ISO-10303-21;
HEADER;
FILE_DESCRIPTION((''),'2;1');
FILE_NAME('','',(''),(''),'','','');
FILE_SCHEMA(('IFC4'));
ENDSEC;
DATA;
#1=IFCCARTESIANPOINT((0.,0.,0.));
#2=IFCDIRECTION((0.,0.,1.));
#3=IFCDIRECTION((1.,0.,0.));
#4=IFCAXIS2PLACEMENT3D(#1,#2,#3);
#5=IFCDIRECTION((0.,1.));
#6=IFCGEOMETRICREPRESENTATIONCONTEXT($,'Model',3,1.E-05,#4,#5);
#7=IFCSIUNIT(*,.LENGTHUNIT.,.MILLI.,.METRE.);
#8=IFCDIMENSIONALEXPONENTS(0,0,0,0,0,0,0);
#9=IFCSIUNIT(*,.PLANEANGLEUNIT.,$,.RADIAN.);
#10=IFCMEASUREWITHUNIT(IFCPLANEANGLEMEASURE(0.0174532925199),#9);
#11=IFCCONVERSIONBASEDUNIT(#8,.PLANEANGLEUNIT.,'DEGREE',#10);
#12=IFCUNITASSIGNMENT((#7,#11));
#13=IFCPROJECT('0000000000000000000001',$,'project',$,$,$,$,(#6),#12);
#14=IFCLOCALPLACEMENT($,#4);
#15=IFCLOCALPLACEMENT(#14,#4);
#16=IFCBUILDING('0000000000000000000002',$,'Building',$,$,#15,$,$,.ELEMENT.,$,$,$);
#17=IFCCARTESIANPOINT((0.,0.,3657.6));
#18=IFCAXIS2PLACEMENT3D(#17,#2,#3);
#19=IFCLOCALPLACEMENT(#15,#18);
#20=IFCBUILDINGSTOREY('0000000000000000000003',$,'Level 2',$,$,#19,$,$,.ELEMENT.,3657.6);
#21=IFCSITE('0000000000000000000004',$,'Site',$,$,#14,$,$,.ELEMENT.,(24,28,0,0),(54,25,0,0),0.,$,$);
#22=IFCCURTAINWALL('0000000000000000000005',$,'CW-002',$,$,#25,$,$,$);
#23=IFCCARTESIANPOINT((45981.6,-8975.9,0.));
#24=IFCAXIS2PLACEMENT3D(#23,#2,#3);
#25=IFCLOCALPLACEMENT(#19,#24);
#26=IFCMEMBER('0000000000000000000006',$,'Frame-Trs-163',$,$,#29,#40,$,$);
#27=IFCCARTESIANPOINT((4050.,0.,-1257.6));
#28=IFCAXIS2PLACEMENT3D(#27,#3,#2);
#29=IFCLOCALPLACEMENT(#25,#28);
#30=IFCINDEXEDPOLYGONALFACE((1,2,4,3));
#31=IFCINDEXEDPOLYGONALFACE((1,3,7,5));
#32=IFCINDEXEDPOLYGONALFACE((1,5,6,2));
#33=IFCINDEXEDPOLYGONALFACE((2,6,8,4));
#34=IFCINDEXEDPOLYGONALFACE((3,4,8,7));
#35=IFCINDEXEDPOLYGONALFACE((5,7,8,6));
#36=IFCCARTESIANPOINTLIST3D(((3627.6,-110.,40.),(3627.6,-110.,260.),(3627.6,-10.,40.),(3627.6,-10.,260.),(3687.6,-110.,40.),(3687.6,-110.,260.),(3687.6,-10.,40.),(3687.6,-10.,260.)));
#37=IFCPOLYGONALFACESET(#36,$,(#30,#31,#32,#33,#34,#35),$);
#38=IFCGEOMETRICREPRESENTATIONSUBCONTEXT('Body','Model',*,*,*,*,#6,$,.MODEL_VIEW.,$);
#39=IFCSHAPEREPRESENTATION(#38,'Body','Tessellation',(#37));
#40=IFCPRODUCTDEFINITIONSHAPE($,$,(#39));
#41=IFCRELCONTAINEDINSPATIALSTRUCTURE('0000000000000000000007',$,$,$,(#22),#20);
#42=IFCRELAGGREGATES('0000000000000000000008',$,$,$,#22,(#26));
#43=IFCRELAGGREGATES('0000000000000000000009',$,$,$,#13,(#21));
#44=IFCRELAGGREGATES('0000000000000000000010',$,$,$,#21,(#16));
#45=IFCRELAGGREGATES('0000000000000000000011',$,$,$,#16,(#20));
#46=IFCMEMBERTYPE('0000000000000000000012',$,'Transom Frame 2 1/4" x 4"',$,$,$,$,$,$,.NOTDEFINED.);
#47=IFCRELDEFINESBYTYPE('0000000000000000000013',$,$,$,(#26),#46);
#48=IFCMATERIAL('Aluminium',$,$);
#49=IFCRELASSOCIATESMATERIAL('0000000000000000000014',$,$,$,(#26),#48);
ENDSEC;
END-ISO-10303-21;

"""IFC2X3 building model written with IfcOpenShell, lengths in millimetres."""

from ifc_helpers import new_model, entity, si_unit, converted_unit, direction, frame, origin_with_axes, place, context, subcontext, project, spatial, polyline, outline, extrude, material, type_object, element, aggregate, save


model = new_model("IFC2X3")

# Units and contexts
model_context = context("Model", 3, precision=1e-05, world=origin_with_axes(), true_north=direction((0.0, 1.0)))
body_context = subcontext(model_context, "Body", "Model", "MODEL_VIEW")
ifc_project = project(units=[si_unit("LENGTHUNIT", "METRE", prefix="MILLI"), converted_unit("PLANEANGLEUNIT", "DEGREE", entity("IfcPlaneAngleMeasure", 0.0174532925199), si_unit("PLANEANGLEUNIT", "RADIAN"), dimensions=[0, 0, 0, 0, 0, 0, 0])], contexts=[model_context])

# Site, building, storey
site_placement = place(None, origin_with_axes())
site = spatial("IfcSite", under=ifc_project, at=site_placement, Name="Site", CompositionType="ELEMENT", RefLatitude=(24, 28, 0, 0), RefLongitude=(54, 25, 0, 0), RefElevation=0.0)
building_placement = place(site_placement, origin_with_axes())
building = spatial("IfcBuilding", under=site, at=building_placement, Name="Building", CompositionType="ELEMENT")
storey_placement = place(building_placement, frame((0.0, 0.0, 3657.6), z_axis=(0.0, 0.0, 1.0), x_axis=(1.0, 0.0, 0.0)))
storey = spatial("IfcBuildingStorey", under=building, at=storey_placement, Name="Level 2", CompositionType="ELEMENT", Elevation=3657.6)

# Curtain wall, member
curtain_wall_placement = place(storey_placement, frame((45981.6, -8975.9, 0.0), z_axis=(0.0, 0.0, 1.0), x_axis=(1.0, 0.0, 0.0)))
curtain_wall = element("IfcCurtainWall", 1, at=curtain_wall_placement, inside=storey, Name="CW-002")
ifc_material_1 = material(Name="Aluminium")
member_type_1 = type_object("IfcMemberType", Name="Transom Frame 2 1/4\" x 4\"", PredefinedType="NOTDEFINED")
member_1_placement = place(curtain_wall_placement, frame((4050.0, 0.0, -1257.6), z_axis=(1.0, 0.0, 0.0), x_axis=(0.0, 0.0, 1.0)))
member_1 = element("IfcMember", 2, at=member_1_placement, type_object=member_type_1, material=ifc_material_1, Name="Frame-Trs-163", context=body_context, shape_type="SweptSolid", body=[
    extrude(outline(polyline([(-110.0, -3687.6), (-10.0, -3687.6), (-10.0, -3627.6), (-110.0, -3627.6), (-110.0, -3687.6)])), frame((0.0, 0.0, 40.0), z_axis=(0.0, 0.0, 1.0), x_axis=(0.0, 1.0, 0.0)), (0.0, 0.0, 1.0), 220.0),
])
aggregate(curtain_wall, [member_1])

save(model, "model.ifc")
